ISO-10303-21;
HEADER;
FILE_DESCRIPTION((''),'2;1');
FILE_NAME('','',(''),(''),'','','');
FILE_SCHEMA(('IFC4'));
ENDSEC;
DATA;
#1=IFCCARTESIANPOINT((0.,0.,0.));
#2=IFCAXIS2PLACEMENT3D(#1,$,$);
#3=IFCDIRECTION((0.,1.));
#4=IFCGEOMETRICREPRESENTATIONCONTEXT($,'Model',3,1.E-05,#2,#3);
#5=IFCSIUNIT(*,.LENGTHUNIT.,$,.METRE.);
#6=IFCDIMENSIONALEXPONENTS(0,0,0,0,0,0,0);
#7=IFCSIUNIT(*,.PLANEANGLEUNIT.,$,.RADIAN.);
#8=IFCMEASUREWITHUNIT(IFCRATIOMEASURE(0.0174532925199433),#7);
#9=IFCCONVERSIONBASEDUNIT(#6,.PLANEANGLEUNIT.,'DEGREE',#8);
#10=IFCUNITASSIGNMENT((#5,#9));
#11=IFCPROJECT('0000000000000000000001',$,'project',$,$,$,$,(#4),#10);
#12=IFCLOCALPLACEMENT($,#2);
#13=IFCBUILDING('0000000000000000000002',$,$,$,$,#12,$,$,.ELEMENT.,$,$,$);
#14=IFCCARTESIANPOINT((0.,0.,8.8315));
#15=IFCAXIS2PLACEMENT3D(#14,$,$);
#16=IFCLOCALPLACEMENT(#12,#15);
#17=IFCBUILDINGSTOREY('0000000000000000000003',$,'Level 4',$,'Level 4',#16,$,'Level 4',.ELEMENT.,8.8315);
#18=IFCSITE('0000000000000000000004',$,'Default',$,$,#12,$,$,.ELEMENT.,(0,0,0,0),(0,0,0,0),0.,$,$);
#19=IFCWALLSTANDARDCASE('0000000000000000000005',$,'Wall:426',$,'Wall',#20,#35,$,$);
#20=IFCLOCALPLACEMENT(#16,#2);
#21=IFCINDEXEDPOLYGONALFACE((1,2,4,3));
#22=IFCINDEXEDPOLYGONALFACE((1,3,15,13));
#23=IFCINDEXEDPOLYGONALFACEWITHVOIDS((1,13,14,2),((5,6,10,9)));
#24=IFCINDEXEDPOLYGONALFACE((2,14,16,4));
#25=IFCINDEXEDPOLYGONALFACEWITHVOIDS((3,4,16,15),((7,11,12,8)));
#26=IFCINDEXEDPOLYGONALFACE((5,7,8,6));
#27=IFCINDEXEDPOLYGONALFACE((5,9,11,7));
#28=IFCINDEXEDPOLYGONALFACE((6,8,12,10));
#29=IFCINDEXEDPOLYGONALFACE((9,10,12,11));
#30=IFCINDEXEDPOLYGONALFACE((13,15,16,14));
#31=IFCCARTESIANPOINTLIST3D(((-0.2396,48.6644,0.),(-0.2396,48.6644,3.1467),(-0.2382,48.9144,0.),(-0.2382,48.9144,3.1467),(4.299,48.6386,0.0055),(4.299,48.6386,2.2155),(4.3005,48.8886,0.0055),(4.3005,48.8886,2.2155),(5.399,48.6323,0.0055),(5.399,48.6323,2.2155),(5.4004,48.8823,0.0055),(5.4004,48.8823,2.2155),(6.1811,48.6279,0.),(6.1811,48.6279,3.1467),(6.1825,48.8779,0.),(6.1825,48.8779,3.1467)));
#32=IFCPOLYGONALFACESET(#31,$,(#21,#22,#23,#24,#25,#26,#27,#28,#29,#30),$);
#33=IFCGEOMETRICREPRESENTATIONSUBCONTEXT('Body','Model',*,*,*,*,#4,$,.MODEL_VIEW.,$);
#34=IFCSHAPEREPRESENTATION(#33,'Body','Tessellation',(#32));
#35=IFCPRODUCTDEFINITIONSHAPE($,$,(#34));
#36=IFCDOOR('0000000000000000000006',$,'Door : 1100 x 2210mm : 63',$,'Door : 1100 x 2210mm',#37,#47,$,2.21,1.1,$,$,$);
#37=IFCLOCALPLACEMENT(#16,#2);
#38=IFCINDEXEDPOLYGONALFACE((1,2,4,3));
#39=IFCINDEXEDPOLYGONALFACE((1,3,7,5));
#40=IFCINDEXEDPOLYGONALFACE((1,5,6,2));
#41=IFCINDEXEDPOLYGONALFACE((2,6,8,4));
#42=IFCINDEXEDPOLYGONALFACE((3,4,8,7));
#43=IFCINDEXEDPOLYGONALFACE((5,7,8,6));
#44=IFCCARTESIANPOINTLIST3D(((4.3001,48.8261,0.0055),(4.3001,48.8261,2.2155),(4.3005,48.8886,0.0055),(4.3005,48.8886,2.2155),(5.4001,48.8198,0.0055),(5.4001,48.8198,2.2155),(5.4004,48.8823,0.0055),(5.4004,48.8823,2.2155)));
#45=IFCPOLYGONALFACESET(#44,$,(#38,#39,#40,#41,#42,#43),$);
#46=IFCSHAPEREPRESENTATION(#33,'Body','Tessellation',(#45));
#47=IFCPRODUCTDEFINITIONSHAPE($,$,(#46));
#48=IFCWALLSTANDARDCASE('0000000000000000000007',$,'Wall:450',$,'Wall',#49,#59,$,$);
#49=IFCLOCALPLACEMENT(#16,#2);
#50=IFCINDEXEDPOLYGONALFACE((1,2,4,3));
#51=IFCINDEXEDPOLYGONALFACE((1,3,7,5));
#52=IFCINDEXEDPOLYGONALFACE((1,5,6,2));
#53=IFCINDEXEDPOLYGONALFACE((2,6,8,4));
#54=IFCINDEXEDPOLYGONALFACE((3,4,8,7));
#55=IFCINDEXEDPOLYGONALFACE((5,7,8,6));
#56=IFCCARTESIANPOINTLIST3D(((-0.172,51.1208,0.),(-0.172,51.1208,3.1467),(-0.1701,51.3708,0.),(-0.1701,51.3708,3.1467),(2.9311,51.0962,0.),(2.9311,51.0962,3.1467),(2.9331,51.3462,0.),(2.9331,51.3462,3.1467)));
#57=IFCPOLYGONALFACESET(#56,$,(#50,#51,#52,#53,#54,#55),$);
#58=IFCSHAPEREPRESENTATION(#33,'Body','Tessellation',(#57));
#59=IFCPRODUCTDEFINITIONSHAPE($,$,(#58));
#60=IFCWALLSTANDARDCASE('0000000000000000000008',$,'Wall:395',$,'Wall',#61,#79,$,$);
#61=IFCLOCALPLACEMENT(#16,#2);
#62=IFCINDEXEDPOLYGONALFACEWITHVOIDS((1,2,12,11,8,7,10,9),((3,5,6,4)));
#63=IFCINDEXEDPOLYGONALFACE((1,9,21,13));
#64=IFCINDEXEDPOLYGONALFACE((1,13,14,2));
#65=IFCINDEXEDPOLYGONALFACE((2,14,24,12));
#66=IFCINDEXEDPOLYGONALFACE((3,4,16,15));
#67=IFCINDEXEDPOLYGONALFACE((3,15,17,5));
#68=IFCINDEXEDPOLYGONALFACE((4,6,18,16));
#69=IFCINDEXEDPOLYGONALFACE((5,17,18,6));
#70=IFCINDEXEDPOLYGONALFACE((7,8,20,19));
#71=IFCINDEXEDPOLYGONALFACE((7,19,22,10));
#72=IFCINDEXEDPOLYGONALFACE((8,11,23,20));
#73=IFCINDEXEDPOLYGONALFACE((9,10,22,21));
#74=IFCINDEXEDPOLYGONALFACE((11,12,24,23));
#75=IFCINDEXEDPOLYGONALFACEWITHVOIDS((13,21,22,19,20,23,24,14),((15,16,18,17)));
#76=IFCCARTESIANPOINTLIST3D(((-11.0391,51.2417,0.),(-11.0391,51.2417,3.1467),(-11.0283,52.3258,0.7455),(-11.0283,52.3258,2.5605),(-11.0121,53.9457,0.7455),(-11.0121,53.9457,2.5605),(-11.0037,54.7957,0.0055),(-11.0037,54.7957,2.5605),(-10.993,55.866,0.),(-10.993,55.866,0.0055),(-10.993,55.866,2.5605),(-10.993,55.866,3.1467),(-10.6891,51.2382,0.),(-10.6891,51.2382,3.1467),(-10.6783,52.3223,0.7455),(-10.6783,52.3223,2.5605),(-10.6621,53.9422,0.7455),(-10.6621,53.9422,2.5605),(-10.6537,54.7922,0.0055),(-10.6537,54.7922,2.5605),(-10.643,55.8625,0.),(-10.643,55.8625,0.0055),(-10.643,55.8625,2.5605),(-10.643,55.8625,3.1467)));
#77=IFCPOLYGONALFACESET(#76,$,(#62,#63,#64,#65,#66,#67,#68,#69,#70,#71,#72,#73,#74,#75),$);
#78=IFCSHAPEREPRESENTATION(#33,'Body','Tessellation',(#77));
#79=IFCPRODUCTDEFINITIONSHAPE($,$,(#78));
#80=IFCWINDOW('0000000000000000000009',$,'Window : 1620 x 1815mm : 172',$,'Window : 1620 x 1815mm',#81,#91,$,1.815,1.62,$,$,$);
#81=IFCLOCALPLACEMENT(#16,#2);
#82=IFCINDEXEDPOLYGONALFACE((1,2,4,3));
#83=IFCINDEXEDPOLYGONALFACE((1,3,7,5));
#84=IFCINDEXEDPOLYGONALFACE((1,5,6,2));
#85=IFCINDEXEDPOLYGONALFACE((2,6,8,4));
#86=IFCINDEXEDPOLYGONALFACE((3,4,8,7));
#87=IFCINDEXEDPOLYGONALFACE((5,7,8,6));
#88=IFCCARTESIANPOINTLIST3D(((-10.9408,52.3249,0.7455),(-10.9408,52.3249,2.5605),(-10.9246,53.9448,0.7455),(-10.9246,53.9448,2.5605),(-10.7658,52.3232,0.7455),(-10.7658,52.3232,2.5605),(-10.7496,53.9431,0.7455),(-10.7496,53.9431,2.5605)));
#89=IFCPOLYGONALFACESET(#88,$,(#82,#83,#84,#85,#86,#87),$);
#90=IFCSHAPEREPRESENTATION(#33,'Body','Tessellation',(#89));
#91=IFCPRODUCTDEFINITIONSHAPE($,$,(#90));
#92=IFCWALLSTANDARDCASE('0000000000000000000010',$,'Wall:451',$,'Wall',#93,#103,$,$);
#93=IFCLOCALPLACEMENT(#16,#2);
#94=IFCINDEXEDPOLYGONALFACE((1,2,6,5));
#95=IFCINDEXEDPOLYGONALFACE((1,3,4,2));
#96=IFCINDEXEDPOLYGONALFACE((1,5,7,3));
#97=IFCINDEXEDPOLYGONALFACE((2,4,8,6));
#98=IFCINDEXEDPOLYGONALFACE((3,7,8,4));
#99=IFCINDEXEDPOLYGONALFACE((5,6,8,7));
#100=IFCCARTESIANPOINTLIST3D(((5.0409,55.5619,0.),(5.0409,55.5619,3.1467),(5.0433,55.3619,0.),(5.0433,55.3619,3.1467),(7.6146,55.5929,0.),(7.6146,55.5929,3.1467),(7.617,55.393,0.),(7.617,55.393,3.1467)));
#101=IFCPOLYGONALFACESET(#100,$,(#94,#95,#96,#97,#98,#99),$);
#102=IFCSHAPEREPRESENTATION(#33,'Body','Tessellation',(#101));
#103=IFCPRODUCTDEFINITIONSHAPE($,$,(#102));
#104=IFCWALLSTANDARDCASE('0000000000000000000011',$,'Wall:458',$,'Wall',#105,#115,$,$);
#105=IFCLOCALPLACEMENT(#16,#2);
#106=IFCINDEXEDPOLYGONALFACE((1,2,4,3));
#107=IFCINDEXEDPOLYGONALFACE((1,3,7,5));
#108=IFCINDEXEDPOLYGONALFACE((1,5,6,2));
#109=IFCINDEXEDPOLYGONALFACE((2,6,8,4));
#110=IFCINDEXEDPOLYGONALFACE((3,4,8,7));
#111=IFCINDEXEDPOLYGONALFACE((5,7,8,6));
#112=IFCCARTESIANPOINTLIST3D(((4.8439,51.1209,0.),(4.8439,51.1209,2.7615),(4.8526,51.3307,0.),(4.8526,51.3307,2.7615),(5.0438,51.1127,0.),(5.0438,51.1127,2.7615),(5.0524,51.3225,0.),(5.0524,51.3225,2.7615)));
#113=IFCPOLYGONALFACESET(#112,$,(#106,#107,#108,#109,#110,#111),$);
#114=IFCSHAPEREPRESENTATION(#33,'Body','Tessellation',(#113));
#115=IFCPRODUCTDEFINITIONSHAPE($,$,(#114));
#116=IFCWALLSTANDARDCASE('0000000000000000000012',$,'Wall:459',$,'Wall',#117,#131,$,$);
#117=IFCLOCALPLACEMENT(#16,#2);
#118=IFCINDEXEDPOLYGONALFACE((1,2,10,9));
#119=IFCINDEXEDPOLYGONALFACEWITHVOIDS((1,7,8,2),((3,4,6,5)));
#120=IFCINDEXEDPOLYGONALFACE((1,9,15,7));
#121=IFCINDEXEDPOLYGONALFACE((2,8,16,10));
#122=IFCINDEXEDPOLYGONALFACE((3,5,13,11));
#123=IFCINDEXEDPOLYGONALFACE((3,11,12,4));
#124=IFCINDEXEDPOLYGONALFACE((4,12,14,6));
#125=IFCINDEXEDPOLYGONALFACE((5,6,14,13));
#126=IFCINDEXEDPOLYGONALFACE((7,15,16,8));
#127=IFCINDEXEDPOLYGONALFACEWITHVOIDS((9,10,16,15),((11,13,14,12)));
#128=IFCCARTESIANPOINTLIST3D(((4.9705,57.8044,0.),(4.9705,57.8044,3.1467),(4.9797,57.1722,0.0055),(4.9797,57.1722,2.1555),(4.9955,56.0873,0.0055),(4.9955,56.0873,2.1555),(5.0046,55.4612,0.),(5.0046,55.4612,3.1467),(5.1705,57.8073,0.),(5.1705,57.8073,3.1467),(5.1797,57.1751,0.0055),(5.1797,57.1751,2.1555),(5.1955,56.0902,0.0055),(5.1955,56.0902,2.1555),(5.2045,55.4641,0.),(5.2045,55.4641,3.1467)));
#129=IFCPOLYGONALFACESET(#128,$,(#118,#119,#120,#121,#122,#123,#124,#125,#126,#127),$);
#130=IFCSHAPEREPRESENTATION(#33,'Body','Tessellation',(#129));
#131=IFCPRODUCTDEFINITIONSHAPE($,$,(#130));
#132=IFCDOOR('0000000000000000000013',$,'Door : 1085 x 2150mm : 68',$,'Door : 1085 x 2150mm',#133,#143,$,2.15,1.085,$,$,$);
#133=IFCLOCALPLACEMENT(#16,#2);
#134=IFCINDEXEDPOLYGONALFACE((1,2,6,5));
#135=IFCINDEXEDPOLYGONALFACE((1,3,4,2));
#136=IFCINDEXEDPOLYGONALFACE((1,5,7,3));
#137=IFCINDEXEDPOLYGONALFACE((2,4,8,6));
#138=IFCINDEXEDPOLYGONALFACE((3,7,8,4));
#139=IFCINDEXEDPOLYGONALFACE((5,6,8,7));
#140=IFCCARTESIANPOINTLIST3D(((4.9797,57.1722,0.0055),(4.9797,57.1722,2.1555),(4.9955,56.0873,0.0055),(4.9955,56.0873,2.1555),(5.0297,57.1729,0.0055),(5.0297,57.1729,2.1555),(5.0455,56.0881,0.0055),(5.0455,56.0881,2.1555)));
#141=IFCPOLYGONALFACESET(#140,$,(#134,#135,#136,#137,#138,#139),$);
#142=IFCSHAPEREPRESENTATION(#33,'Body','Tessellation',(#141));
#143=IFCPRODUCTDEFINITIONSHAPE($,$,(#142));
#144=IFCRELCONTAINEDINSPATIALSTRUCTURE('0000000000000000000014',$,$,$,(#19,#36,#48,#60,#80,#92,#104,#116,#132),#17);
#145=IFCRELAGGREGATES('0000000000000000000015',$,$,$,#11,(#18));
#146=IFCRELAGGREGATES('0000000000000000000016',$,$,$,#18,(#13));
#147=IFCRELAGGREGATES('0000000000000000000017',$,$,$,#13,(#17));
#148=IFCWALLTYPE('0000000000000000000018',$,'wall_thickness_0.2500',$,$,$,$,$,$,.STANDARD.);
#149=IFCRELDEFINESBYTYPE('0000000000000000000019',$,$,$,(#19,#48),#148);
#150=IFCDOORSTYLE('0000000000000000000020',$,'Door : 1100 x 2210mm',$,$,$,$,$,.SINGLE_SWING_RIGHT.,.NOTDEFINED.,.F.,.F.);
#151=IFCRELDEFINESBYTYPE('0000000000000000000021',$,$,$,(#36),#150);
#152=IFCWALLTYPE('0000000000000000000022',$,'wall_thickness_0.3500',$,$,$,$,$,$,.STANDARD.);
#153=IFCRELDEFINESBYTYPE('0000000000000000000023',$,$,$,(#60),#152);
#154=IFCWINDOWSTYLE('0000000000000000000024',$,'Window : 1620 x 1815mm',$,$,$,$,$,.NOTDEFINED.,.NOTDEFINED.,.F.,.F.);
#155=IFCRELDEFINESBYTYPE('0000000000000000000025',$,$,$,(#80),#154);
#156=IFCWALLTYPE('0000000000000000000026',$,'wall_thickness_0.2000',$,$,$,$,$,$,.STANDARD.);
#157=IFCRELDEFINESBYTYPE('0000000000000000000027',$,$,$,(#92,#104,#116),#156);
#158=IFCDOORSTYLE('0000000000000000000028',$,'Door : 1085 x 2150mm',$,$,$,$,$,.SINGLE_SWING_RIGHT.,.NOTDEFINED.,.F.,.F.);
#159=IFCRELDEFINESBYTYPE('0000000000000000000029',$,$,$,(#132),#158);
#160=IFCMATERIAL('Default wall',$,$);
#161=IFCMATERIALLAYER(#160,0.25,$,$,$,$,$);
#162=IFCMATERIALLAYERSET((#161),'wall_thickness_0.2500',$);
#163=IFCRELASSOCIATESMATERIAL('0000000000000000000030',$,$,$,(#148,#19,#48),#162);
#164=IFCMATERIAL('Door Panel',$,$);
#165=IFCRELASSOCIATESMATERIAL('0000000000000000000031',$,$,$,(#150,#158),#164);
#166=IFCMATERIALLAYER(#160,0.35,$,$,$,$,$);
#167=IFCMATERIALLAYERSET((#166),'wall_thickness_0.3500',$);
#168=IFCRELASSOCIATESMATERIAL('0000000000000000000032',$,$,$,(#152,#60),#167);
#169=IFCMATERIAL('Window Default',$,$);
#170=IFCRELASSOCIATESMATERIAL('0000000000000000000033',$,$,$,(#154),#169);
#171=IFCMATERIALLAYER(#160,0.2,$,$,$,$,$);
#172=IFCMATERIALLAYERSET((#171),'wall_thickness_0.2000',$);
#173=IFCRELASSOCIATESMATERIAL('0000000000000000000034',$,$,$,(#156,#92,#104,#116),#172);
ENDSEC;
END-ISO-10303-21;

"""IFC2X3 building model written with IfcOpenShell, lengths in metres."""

from ifc_helpers import new_model, entity, si_unit, converted_unit, direction, frame, frame_2d, origin, origin_2d_with_axis, place, context, subcontext, project, spatial, polyline, rectangle, outline, extrude, source, transform, mapped, material, layer, layer_set, layer_usage, type_object, type_shapes, element, fill, save


model = new_model("IFC2X3")

# Units and contexts
model_context = context("Model", 3, precision=1e-05, world=origin(), true_north=direction((0.0, 1.0)))
body_context = subcontext(model_context, "Body", "Model", "MODEL_VIEW")
ifc_project = project(units=[si_unit("LENGTHUNIT", "METRE"), converted_unit("PLANEANGLEUNIT", "DEGREE", entity("IfcRatioMeasure", 0.0174532925199433), si_unit("PLANEANGLEUNIT", "RADIAN"), dimensions=[0, 0, 0, 0, 0, 0, 0])], contexts=[model_context])

# Site, building, storey
placement_1 = place(None, origin())
site = spatial("IfcSite", under=ifc_project, at=placement_1, Name="Default", CompositionType="ELEMENT", RefLatitude=(0, 0, 0, 0), RefLongitude=(0, 0, 0, 0), RefElevation=0.0)
building = spatial("IfcBuilding", under=site, at=placement_1, CompositionType="ELEMENT")
storey_placement = place(placement_1, frame((0.0, 0.0, 8.8315)))
storey = spatial("IfcBuildingStorey", under=building, at=storey_placement, Name="Level 4", ObjectType="Level 4", LongName="Level 4", CompositionType="ELEMENT", Elevation=8.8315)

# Wall, opening, door
ifc_material_1 = material(Name="Default wall")
ifc_layer_1 = layer(ifc_material_1, 0.25)
ifc_layer_set_1 = layer_set([ifc_layer_1], Name="wall_thickness_0.2500")
ifc_layer_usage_1 = layer_usage(ifc_layer_set_1, "AXIS2", "POSITIVE", -0.125)
wall_type_1 = type_object("IfcWallType", Name="wall_thickness_0.2500", PredefinedType="STANDARD", material=ifc_layer_set_1)
wall_1_placement = place(storey_placement, frame((-0.2389, 48.7894, 0.0), z_axis=(0.0, 0.0, 1.0), x_axis=(0.999984, -0.005692, 0.0)))
wall_1 = element("IfcWallStandardCase", 1, at=wall_1_placement, inside=storey, type_object=wall_type_1, material=ifc_layer_usage_1, Name="Wall:426", ObjectType="Wall", context=body_context, shape_type="SweptSolid", body=[
    extrude(outline(polyline([(6.4208, -0.125), (6.4208, 0.125), (0.0, 0.125), (0.0, -0.125), (6.4208, -0.125)])), origin(), (0.0, 0.0, 1.0), 3.1467),
])
opening_1_placement = place(wall_1_placement, frame((4.5387, -0.125, 0.0055)))
opening_1 = element("IfcOpeningElement", 2, at=opening_1_placement, cuts=wall_1, ObjectType="Opening", context=body_context, shape_type="SweptSolid", body=[
    extrude(rectangle(XDim=1.1, YDim=2.21, at=frame_2d((1.105, 0.55), x_axis=(0.0, 1.0))), frame((0.0, 0.0, 0.0), z_axis=(0.0, 1.0, 0.0), x_axis=(0.0, 0.0, 1.0)), (0.0, 0.0, 1.0), 0.25),
])
ifc_material_2 = material(Name="Door Panel")
door_style_1 = type_object("IfcDoorStyle", Name="Door : 1100 x 2210mm", ConstructionType="NOTDEFINED", OperationType="SINGLE_SWING_RIGHT", ParameterTakesPrecedence=False, Sizeable=False, material=ifc_material_2)
shared_shape_1 = source(origin(), body_context, "Body", "SweptSolid", [
    extrude(rectangle(XDim=0.0625, YDim=1.1, at=origin_2d_with_axis()), frame((0.55, 0.2188, 0.0), z_axis=(0.0, 0.0, 1.0), x_axis=(0.0, 1.0, 0.0)), (0.0, 0.0, 1.0), 2.21),
])
type_shapes(door_style_1, [shared_shape_1])
door_1_placement = place(opening_1_placement, origin())
door_1 = element("IfcDoor", 3, at=door_1_placement, inside=storey, type_object=door_style_1, Name="Door : 1100 x 2210mm : 63", ObjectType="Door : 1100 x 2210mm", OverallHeight=2.21, OverallWidth=1.1, context=body_context, shape_type="MappedRepresentation", body=[
    mapped(shared_shape_1, transform((0.0, 0.0, 0.0), scale=1.0)),
])
fill(opening_1, door_1)

# Wall
wall_2_placement = place(storey_placement, frame((-0.1711, 51.2458, 0.0), z_axis=(0.0, 0.0, 1.0), x_axis=(0.999969, -0.007931, 0.0)))
element("IfcWallStandardCase", 4, at=wall_2_placement, inside=storey, type_object=wall_type_1, material=ifc_layer_usage_1, Name="Wall:450", ObjectType="Wall", context=body_context, shape_type="SweptSolid", body=[
    extrude(outline(polyline([(3.1033, -0.125), (3.1033, 0.125), (0.0, 0.125), (0.0, -0.125), (3.1033, -0.125)])), origin(), (0.0, 0.0, 1.0), 3.1467),
])

# Wall, openings, window
ifc_layer_2 = layer(ifc_material_1, 0.35)
ifc_layer_set_2 = layer_set([ifc_layer_2], Name="wall_thickness_0.3500")
ifc_layer_usage_2 = layer_usage(ifc_layer_set_2, "AXIS2", "POSITIVE", -0.175)
wall_type_2 = type_object("IfcWallType", Name="wall_thickness_0.3500", PredefinedType="STANDARD", material=ifc_layer_set_2)
wall_3_placement = place(storey_placement, frame((-10.818, 55.8643, 0.0), z_axis=(0.0, 0.0, 1.0), x_axis=(-0.009962, -0.99995, 0.0)))
wall_3 = element("IfcWallStandardCase", 5, at=wall_3_placement, inside=storey, type_object=wall_type_2, material=ifc_layer_usage_2, Name="Wall:395", ObjectType="Wall", context=body_context, shape_type="SweptSolid", body=[
    extrude(outline(polyline([(4.6245, -0.175), (4.6245, 0.175), (0.0, 0.175), (0.0, -0.175), (4.6245, -0.175)])), origin(), (0.0, 0.0, 1.0), 3.1467),
])
opening_2_placement = place(wall_3_placement, frame((-0.9096, -0.175, 0.0055)))
element("IfcOpeningElement", 6, at=opening_2_placement, cuts=wall_3, ObjectType="Opening", context=body_context, shape_type="SweptSolid", body=[
    extrude(rectangle(XDim=1.98, YDim=2.555, at=frame_2d((1.2775, 0.99), x_axis=(0.0, 1.0))), frame((0.0, 0.0, 0.0), z_axis=(0.0, 1.0, 0.0), x_axis=(0.0, 0.0, 1.0)), (0.0, 0.0, 1.0), 0.35),
])
opening_3_placement = place(wall_3_placement, frame((1.9204, -0.175, 0.7455)))
opening_3 = element("IfcOpeningElement", 7, at=opening_3_placement, cuts=wall_3, ObjectType="Opening", context=body_context, shape_type="SweptSolid", body=[
    extrude(rectangle(XDim=1.62, YDim=1.815, at=frame_2d((0.9075, 0.81), x_axis=(0.0, 1.0))), frame((0.0, 0.0, 0.0), z_axis=(0.0, 1.0, 0.0), x_axis=(0.0, 0.0, 1.0)), (0.0, 0.0, 1.0), 0.35),
])
ifc_material_3 = material(Name="Window Default")
window_style_1 = type_object("IfcWindowStyle", Name="Window : 1620 x 1815mm", ConstructionType="NOTDEFINED", OperationType="NOTDEFINED", ParameterTakesPrecedence=False, Sizeable=False, material=ifc_material_3)
shared_shape_2 = source(origin(), body_context, "Body", "SweptSolid", [
    extrude(rectangle(XDim=0.175, YDim=1.62, at=origin_2d_with_axis()), frame((0.81, 0.175, 0.0), z_axis=(0.0, 0.0, 1.0), x_axis=(0.0, 1.0, 0.0)), (0.0, 0.0, 1.0), 1.815),
])
type_shapes(window_style_1, [shared_shape_2])
window_1_placement = place(opening_3_placement, origin())
window_1 = element("IfcWindow", 8, at=window_1_placement, inside=storey, type_object=window_style_1, Name="Window : 1620 x 1815mm : 172", ObjectType="Window : 1620 x 1815mm", OverallHeight=1.815, OverallWidth=1.62, context=body_context, shape_type="MappedRepresentation", body=[
    mapped(shared_shape_2, transform((0.0, 0.0, 0.0), scale=1.0)),
])
fill(opening_3, window_1)

# Walls
ifc_layer_3 = layer(ifc_material_1, 0.2)
ifc_layer_set_3 = layer_set([ifc_layer_3], Name="wall_thickness_0.2000")
ifc_layer_usage_3 = layer_usage(ifc_layer_set_3, "AXIS2", "POSITIVE", -0.1)
wall_type_3 = type_object("IfcWallType", Name="wall_thickness_0.2000", PredefinedType="STANDARD", material=ifc_layer_set_3)
wall_4_placement = place(storey_placement, frame((5.0421, 55.4619, 0.0), z_axis=(0.0, 0.0, 1.0), x_axis=(0.999927, 0.012055, 0.0)))
element("IfcWallStandardCase", 9, at=wall_4_placement, inside=storey, type_object=wall_type_3, material=ifc_layer_usage_3, Name="Wall:451", ObjectType="Wall", context=body_context, shape_type="SweptSolid", body=[
    extrude(outline(polyline([(2.5739, -0.1), (2.5739, 0.1), (0.0, 0.1), (0.0, -0.1), (2.5739, -0.1)])), origin(), (0.0, 0.0, 1.0), 3.1467),
])
wall_5_placement = place(storey_placement, frame((4.9525, 51.3266, 0.0), z_axis=(0.0, 0.0, 1.0), x_axis=(-0.041288, -0.999147, 0.0)))
element("IfcWallStandardCase", 10, at=wall_5_placement, inside=storey, type_object=wall_type_3, material=ifc_layer_usage_3, Name="Wall:458", ObjectType="Wall", context=body_context, shape_type="SweptSolid", body=[
    extrude(outline(polyline([(0.21, -0.1), (0.21, 0.1), (0.0, 0.1), (0.0, -0.1), (0.21, -0.1)])), origin(), (0.0, 0.0, 1.0), 2.7615),
])

# Wall, opening, door
wall_6_placement = place(storey_placement, frame((5.1046, 55.4627, 0.0), z_axis=(0.0, 0.0, 1.0), x_axis=(-0.014524, 0.999895, 0.0)))
wall_6 = element("IfcWallStandardCase", 11, at=wall_6_placement, inside=storey, type_object=wall_type_3, material=ifc_layer_usage_3, Name="Wall:459", ObjectType="Wall", context=body_context, shape_type="SweptSolid", body=[
    extrude(outline(polyline([(2.3434, -0.1), (2.3434, 0.1), (0.0, 0.1), (0.0, -0.1), (2.3434, -0.1)])), origin(), (0.0, 0.0, 1.0), 3.1467),
])
opening_4_placement = place(wall_6_placement, frame((0.6262, -0.1, 0.0055)))
opening_4 = element("IfcOpeningElement", 12, at=opening_4_placement, cuts=wall_6, ObjectType="Opening", context=body_context, shape_type="SweptSolid", body=[
    extrude(rectangle(XDim=1.085, YDim=2.15, at=frame_2d((1.075, 0.5425), x_axis=(0.0, 1.0))), frame((0.0, 0.0, 0.0), z_axis=(0.0, 1.0, 0.0), x_axis=(0.0, 0.0, 1.0)), (0.0, 0.0, 1.0), 0.2),
])
door_style_2 = type_object("IfcDoorStyle", Name="Door : 1085 x 2150mm", ConstructionType="NOTDEFINED", OperationType="SINGLE_SWING_RIGHT", ParameterTakesPrecedence=False, Sizeable=False, material=ifc_material_2)
shared_shape_3 = source(origin(), body_context, "Body", "SweptSolid", [
    extrude(rectangle(XDim=0.05, YDim=1.085, at=origin_2d_with_axis()), frame((0.5425, 0.175, 0.0), z_axis=(0.0, 0.0, 1.0), x_axis=(0.0, 1.0, 0.0)), (0.0, 0.0, 1.0), 2.15),
])
type_shapes(door_style_2, [shared_shape_3])
door_2_placement = place(opening_4_placement, origin())
door_2 = element("IfcDoor", 13, at=door_2_placement, inside=storey, type_object=door_style_2, Name="Door : 1085 x 2150mm : 68", ObjectType="Door : 1085 x 2150mm", OverallHeight=2.15, OverallWidth=1.085, context=body_context, shape_type="MappedRepresentation", body=[
    mapped(shared_shape_3, transform((0.0, 0.0, 0.0), scale=1.0)),
])
fill(opening_4, door_2)

save(model, "model.ifc")
